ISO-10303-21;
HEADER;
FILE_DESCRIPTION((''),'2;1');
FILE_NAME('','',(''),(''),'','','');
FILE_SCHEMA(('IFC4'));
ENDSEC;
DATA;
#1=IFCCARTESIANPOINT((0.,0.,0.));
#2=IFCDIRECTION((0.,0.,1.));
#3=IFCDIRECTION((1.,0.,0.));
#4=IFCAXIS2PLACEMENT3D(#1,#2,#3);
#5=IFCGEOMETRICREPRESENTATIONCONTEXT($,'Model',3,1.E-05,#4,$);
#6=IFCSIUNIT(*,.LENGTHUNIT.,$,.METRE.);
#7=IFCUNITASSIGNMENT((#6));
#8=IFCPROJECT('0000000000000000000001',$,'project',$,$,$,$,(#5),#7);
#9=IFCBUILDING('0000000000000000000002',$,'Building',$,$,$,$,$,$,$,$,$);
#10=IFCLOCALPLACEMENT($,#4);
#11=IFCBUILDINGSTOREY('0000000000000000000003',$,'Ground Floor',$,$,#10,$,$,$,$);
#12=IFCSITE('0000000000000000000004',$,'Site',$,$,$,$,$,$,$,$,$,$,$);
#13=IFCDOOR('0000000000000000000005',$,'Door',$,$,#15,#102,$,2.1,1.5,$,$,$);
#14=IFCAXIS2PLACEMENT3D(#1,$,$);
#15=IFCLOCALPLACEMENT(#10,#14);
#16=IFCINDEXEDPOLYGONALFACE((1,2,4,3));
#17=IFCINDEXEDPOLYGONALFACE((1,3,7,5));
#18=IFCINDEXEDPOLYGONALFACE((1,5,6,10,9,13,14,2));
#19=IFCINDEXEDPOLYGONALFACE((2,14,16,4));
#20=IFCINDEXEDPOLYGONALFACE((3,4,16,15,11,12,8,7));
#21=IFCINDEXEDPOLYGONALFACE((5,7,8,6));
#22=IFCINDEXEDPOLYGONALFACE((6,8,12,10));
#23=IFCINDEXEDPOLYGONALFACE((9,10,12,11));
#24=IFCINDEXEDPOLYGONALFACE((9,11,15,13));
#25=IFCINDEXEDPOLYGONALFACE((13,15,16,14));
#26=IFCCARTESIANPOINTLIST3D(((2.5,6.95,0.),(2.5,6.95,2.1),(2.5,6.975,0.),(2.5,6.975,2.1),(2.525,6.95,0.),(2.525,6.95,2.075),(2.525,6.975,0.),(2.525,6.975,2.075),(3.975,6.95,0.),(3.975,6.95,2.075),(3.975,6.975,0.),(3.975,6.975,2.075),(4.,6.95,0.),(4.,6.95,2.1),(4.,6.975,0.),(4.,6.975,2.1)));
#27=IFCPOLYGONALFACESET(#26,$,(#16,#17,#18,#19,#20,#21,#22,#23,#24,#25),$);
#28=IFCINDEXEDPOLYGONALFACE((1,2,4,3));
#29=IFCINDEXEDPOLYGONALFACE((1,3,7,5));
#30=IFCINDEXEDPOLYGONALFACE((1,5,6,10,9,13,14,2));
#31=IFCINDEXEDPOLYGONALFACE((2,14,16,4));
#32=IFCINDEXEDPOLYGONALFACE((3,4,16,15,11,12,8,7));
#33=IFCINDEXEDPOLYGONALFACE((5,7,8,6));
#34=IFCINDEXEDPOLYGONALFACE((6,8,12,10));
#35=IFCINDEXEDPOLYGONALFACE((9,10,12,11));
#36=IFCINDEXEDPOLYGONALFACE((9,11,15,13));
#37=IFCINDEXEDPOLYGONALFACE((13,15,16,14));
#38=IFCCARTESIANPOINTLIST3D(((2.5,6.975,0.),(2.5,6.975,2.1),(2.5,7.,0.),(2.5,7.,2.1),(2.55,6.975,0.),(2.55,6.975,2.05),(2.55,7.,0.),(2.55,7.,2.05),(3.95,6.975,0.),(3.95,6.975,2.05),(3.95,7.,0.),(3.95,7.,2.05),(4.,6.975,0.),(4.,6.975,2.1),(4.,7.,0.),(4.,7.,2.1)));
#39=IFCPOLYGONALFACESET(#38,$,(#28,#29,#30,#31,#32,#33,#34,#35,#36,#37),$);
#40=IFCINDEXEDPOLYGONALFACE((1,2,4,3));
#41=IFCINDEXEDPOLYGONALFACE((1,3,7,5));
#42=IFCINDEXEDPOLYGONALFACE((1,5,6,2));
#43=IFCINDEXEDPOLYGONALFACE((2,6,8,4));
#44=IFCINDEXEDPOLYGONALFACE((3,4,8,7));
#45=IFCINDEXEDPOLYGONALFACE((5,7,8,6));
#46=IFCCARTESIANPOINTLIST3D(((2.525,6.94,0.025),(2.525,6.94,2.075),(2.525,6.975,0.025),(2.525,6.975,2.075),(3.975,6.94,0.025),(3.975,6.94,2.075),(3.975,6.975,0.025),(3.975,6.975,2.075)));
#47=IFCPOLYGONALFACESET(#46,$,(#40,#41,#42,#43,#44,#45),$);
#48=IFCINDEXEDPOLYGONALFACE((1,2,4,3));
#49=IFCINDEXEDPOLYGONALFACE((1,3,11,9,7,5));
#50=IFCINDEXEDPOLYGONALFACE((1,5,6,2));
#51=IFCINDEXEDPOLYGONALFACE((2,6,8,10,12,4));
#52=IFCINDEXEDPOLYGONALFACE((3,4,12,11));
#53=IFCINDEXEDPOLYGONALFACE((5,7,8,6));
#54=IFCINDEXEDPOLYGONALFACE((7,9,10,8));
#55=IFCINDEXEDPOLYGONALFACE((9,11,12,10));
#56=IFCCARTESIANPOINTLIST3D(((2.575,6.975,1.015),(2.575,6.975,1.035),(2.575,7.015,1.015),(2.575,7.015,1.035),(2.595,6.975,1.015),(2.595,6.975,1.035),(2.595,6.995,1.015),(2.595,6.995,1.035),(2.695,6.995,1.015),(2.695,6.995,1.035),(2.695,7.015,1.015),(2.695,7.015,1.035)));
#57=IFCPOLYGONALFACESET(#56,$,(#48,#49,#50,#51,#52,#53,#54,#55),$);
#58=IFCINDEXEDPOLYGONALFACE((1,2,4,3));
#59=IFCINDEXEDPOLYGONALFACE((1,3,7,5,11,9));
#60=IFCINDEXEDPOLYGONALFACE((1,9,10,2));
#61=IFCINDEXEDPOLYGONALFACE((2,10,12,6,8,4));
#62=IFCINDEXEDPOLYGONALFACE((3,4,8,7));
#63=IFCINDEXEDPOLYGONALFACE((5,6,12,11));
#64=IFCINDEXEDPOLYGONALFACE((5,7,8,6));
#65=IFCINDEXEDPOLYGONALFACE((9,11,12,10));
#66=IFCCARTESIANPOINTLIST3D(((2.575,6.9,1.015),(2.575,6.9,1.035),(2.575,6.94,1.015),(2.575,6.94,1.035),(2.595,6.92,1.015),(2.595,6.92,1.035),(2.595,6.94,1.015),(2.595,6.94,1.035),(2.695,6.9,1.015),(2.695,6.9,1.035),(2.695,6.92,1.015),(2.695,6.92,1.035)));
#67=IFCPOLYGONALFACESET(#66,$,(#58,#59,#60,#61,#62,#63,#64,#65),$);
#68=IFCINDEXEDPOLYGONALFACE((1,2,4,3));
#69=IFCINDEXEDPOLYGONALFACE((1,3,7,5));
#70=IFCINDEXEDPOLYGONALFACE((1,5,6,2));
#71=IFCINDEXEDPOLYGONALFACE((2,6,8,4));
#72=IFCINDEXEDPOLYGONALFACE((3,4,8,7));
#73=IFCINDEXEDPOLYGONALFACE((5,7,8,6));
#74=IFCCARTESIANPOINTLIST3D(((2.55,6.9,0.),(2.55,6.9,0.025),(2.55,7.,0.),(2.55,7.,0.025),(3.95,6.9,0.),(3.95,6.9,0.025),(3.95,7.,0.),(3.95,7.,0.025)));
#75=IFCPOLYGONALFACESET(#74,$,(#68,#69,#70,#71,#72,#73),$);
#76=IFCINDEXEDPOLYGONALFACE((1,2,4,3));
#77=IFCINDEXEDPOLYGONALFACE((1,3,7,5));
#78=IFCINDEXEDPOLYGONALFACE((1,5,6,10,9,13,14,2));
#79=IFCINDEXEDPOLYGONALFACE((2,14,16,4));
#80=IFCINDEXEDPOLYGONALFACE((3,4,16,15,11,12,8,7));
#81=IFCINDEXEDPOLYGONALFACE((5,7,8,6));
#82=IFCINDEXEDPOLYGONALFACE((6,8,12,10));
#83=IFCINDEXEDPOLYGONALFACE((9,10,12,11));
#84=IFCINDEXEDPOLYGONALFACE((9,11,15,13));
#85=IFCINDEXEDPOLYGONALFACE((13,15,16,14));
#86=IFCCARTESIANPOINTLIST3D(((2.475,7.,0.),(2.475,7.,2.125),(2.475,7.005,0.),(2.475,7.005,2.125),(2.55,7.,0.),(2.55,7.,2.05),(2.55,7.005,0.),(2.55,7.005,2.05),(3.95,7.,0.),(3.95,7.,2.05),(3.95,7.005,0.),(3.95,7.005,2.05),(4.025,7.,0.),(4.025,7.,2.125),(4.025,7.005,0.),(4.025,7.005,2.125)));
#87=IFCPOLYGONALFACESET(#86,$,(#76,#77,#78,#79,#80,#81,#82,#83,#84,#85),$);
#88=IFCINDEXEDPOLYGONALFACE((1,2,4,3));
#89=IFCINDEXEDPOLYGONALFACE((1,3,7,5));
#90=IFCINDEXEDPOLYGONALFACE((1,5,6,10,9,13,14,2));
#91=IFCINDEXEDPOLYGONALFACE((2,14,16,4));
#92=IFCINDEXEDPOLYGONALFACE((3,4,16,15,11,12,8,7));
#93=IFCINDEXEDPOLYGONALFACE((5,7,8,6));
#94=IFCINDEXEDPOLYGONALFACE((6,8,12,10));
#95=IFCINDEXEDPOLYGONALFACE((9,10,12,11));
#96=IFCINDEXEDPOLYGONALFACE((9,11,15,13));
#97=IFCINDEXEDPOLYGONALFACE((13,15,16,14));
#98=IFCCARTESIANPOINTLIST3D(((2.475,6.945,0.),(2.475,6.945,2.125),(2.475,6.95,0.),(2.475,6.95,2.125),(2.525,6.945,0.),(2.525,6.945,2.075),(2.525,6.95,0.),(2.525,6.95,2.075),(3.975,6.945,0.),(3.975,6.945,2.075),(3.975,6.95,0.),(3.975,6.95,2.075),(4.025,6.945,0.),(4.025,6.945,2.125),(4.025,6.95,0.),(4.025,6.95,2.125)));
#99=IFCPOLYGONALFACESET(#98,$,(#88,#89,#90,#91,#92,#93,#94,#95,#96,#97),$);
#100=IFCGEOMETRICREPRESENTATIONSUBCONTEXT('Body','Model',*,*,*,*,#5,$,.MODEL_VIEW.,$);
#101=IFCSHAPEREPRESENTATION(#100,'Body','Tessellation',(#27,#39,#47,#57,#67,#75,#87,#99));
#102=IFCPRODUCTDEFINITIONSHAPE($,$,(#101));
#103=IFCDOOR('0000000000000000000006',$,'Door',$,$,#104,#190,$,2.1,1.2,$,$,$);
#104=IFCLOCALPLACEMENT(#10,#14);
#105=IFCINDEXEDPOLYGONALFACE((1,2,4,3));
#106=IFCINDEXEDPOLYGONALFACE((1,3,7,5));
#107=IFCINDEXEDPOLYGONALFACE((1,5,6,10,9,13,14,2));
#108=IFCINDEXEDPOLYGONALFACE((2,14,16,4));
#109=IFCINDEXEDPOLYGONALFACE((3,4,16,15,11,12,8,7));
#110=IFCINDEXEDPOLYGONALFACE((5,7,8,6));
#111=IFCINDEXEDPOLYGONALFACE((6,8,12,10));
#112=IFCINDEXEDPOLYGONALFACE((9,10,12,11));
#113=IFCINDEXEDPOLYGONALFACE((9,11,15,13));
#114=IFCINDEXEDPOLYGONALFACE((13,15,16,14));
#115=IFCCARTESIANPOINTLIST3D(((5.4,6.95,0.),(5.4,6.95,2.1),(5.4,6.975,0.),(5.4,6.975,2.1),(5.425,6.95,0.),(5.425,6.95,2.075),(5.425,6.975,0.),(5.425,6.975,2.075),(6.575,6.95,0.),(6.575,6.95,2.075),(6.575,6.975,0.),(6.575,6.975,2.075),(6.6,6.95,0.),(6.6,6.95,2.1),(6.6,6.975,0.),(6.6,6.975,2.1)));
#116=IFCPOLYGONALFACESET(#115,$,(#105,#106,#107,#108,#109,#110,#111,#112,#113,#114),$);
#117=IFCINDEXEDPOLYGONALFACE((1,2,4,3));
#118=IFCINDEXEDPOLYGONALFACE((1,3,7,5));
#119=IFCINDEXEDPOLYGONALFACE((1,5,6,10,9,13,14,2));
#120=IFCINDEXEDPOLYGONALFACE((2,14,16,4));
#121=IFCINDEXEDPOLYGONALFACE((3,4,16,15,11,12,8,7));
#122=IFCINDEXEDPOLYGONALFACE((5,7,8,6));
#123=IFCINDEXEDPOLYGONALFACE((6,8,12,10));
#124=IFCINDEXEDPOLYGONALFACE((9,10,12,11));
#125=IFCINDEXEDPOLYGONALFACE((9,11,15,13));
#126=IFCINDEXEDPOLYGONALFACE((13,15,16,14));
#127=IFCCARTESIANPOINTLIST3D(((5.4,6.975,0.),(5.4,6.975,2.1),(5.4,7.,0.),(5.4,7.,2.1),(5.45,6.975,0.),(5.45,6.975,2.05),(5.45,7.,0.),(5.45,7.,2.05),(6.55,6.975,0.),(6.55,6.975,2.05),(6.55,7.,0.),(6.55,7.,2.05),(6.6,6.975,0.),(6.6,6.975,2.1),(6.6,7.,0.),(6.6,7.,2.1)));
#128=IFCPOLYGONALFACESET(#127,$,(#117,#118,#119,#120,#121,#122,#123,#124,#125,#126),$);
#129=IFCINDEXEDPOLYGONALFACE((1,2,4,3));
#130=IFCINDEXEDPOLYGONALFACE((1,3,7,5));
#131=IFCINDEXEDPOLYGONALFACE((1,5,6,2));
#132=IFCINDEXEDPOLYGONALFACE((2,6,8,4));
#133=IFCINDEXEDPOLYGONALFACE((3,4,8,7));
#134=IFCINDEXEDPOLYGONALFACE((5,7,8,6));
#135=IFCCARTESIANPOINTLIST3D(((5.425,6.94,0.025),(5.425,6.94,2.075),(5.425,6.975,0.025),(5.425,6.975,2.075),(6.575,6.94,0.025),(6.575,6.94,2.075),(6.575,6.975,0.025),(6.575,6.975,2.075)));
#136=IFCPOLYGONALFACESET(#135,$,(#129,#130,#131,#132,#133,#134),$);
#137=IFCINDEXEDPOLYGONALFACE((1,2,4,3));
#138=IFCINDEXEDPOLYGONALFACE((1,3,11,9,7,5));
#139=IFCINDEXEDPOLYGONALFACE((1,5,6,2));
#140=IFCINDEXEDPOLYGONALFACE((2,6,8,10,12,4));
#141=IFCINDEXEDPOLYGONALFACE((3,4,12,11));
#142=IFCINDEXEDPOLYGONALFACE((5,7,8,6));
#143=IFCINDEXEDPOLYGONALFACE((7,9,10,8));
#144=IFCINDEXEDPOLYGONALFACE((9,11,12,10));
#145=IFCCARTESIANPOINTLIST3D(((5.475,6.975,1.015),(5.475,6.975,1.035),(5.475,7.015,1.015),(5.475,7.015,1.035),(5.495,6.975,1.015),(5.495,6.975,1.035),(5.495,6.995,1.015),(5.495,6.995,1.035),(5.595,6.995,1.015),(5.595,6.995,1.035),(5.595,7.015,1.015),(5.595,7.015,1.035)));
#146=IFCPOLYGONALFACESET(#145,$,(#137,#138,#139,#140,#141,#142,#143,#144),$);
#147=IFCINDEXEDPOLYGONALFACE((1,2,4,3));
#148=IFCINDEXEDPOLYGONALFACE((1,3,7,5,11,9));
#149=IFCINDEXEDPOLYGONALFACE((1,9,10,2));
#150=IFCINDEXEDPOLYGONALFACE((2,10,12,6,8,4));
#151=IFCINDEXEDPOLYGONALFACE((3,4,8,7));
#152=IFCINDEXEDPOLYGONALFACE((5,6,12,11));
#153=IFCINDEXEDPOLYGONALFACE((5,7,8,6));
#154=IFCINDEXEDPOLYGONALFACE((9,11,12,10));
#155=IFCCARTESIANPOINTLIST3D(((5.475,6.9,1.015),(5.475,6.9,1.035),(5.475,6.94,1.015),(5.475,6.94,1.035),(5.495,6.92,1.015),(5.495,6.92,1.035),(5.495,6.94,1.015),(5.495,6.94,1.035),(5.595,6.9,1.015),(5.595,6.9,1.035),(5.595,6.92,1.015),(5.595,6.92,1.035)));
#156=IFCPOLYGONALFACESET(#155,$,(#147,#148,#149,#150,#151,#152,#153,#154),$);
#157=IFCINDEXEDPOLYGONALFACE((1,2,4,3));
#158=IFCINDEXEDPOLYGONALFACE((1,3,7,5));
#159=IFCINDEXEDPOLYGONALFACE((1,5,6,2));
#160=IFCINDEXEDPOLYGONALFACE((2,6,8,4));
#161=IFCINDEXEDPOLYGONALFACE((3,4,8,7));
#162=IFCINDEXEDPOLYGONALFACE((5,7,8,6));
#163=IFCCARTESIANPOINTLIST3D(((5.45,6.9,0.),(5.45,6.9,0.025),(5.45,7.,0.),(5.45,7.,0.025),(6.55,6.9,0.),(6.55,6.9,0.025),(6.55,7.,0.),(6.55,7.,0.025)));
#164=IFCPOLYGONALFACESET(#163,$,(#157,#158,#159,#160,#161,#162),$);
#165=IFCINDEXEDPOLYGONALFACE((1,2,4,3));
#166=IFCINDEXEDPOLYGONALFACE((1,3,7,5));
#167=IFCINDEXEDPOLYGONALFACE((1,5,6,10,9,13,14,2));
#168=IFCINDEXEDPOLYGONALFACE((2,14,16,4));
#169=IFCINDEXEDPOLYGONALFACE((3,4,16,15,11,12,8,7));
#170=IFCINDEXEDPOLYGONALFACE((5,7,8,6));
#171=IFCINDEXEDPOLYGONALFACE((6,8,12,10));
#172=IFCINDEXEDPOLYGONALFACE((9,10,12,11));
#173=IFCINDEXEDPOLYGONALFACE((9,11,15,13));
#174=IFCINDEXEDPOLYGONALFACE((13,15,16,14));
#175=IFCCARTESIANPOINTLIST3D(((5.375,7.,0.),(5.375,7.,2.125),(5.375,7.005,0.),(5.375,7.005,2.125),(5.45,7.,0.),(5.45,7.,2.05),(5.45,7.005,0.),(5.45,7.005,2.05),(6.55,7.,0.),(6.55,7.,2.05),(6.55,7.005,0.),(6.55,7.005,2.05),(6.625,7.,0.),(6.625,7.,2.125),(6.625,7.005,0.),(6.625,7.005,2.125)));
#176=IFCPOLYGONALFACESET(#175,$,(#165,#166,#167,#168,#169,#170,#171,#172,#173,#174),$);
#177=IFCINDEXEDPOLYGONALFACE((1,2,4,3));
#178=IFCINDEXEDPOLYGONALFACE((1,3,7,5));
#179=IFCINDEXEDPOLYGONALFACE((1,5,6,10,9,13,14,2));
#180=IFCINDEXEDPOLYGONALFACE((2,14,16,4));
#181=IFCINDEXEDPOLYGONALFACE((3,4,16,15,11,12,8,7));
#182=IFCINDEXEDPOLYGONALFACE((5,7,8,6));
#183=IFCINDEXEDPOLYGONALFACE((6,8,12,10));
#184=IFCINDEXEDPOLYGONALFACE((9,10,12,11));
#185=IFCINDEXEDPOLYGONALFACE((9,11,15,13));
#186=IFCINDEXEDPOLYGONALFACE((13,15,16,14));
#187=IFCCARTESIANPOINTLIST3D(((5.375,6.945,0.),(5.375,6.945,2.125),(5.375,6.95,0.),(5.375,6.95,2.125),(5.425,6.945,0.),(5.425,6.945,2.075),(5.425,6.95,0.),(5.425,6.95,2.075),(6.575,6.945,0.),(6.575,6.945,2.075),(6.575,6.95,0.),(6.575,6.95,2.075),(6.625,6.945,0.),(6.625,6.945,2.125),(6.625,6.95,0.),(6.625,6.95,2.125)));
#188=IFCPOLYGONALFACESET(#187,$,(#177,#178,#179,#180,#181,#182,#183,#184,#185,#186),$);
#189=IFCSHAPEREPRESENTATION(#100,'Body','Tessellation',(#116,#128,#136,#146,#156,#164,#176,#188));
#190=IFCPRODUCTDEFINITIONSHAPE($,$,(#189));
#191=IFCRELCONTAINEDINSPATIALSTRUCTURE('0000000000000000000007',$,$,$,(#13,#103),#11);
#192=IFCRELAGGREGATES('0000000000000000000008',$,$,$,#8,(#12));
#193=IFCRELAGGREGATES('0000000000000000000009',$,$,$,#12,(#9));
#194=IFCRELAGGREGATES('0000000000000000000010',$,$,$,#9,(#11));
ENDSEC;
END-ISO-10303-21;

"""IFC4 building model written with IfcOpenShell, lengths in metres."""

from ifc_helpers import new_model, si_unit, frame, origin_with_axes, place, context, subcontext, project, spatial, line, indexed_curve, outline, extrude, element, save


model = new_model("IFC4")

# Units and contexts
model_context = context("Model", 3, precision=1e-05, world=origin_with_axes())
body_context = subcontext(model_context, "Body", "Model", "MODEL_VIEW")
ifc_project = project(units=[si_unit("LENGTHUNIT", "METRE")], contexts=[model_context])

# Site, building, storey
site = spatial("IfcSite", under=ifc_project, Name="Site")
building = spatial("IfcBuilding", under=site, Name="Building")
storey_placement = place(None, origin_with_axes())
storey = spatial("IfcBuildingStorey", under=building, at=storey_placement, Name="Ground Floor")

# Doors
door_1_placement = place(storey_placement, frame((4.0, 7.0, 0.0), z_axis=(0.0, 0.0, 1.0), x_axis=(-1.0, 0.0, 0.0)))
element("IfcDoor", 1, at=door_1_placement, inside=storey, Name="Door", OverallHeight=2.1, OverallWidth=1.5, context=body_context, shape_type="SweptSolid", body=[
    extrude(outline(indexed_curve([(0.0, 0.0), (0.0, 2.1), (1.5, 2.1), (1.5, 0.0), (1.475, 0.0), (1.475, 2.075), (0.025, 2.075), (0.025, 0.0)], segments=[line(1, 2, 3, 4, 5, 6, 7, 8, 1)])), frame((0.0, 0.025, 0.0), z_axis=(0.0, -1.0, 0.0), x_axis=(1.0, 0.0, 0.0)), (0.0, 0.0, -1.0), 0.025),
    extrude(outline(indexed_curve([(0.0, 0.0), (0.0, 2.1), (1.5, 2.1), (1.5, 0.0), (1.45, 0.0), (1.45, 2.05), (0.05, 2.05), (0.05, 0.0)], segments=[line(1, 2, 3, 4, 5, 6, 7, 8, 1)])), frame((0.0, 0.0, 0.0), z_axis=(0.0, -1.0, 0.0), x_axis=(1.0, 0.0, 0.0)), (0.0, 0.0, -1.0), 0.025),
    extrude(outline(indexed_curve([(0.0, 0.0), (1.45, 0.0), (1.45, 0.035), (0.0, 0.035)], segments=[line(1, 2, 3, 4, 1)])), frame((0.025, 0.025, 0.025), z_axis=(0.0, 0.0, 1.0), x_axis=(1.0, 0.0, 0.0)), (0.0, 0.0, 1.0), 2.05),
    extrude(outline(indexed_curve([(0.0, 0.0), (0.0, -0.04), (-0.12, -0.04), (-0.12, -0.02), (-0.02, -0.02), (-0.02, 0.0)], segments=[line(1, 2, 3, 4, 5, 6, 1)])), frame((1.425, 0.025, 1.015), z_axis=(0.0, 0.0, 1.0), x_axis=(1.0, 0.0, 0.0)), (0.0, 0.0, 1.0), 0.02),
    extrude(outline(indexed_curve([(0.0, 0.0), (0.0, 0.04), (-0.12, 0.04), (-0.12, 0.02), (-0.02, 0.02), (-0.02, 0.0)], segments=[line(1, 2, 3, 4, 5, 6, 1)])), frame((1.425, 0.06, 1.015), z_axis=(0.0, 0.0, 1.0), x_axis=(1.0, 0.0, 0.0)), (0.0, 0.0, 1.0), 0.02),
    extrude(outline(indexed_curve([(0.0, 0.0), (1.4, 0.0), (1.4, 0.1), (0.0, 0.1)], segments=[line(1, 2, 3, 4, 1)])), frame((0.05, 0.0, 0.0), z_axis=(0.0, 0.0, 1.0), x_axis=(1.0, 0.0, 0.0)), (0.0, 0.0, 1.0), 0.025),
    extrude(outline(indexed_curve([(0.0, 0.0), (0.0, 2.125), (1.55, 2.125), (1.55, 0.0), (1.475, 0.0), (1.475, 2.05), (0.075, 2.05), (0.075, 0.0)], segments=[line(1, 2, 3, 4, 5, 6, 7, 8, 1)])), frame((-0.025, -0.005, 0.0), z_axis=(0.0, -1.0, 0.0), x_axis=(1.0, 0.0, 0.0)), (0.0, 0.0, -1.0), 0.005),
    extrude(outline(indexed_curve([(0.0, 0.0), (0.0, 2.125), (1.55, 2.125), (1.55, 0.0), (1.5, 0.0), (1.5, 2.075), (0.05, 2.075), (0.05, 0.0)], segments=[line(1, 2, 3, 4, 5, 6, 7, 8, 1)])), frame((-0.025, 0.05, 0.0), z_axis=(0.0, -1.0, 0.0), x_axis=(1.0, 0.0, 0.0)), (0.0, 0.0, -1.0), 0.005),
])
door_2_placement = place(storey_placement, frame((6.6, 7.0, 0.0), z_axis=(0.0, 0.0, 1.0), x_axis=(-1.0, 0.0, 0.0)))
element("IfcDoor", 2, at=door_2_placement, inside=storey, Name="Door", OverallHeight=2.1, OverallWidth=1.2, context=body_context, shape_type="SweptSolid", body=[
    extrude(outline(indexed_curve([(0.0, 0.0), (0.0, 2.1), (1.2, 2.1), (1.2, 0.0), (1.175, 0.0), (1.175, 2.075), (0.025, 2.075), (0.025, 0.0)], segments=[line(1, 2, 3, 4, 5, 6, 7, 8, 1)])), frame((0.0, 0.025, 0.0), z_axis=(0.0, -1.0, 0.0), x_axis=(1.0, 0.0, 0.0)), (0.0, 0.0, -1.0), 0.025),
    extrude(outline(indexed_curve([(0.0, 0.0), (0.0, 2.1), (1.2, 2.1), (1.2, 0.0), (1.15, 0.0), (1.15, 2.05), (0.05, 2.05), (0.05, 0.0)], segments=[line(1, 2, 3, 4, 5, 6, 7, 8, 1)])), frame((0.0, 0.0, 0.0), z_axis=(0.0, -1.0, 0.0), x_axis=(1.0, 0.0, 0.0)), (0.0, 0.0, -1.0), 0.025),
    extrude(outline(indexed_curve([(0.0, 0.0), (1.15, 0.0), (1.15, 0.035), (0.0, 0.035)], segments=[line(1, 2, 3, 4, 1)])), frame((0.025, 0.025, 0.025), z_axis=(0.0, 0.0, 1.0), x_axis=(1.0, 0.0, 0.0)), (0.0, 0.0, 1.0), 2.05),
    extrude(outline(indexed_curve([(0.0, 0.0), (0.0, -0.04), (-0.12, -0.04), (-0.12, -0.02), (-0.02, -0.02), (-0.02, 0.0)], segments=[line(1, 2, 3, 4, 5, 6, 1)])), frame((1.125, 0.025, 1.015), z_axis=(0.0, 0.0, 1.0), x_axis=(1.0, 0.0, 0.0)), (0.0, 0.0, 1.0), 0.02),
    extrude(outline(indexed_curve([(0.0, 0.0), (0.0, 0.04), (-0.12, 0.04), (-0.12, 0.02), (-0.02, 0.02), (-0.02, 0.0)], segments=[line(1, 2, 3, 4, 5, 6, 1)])), frame((1.125, 0.06, 1.015), z_axis=(0.0, 0.0, 1.0), x_axis=(1.0, 0.0, 0.0)), (0.0, 0.0, 1.0), 0.02),
    extrude(outline(indexed_curve([(0.0, 0.0), (1.1, 0.0), (1.1, 0.1), (0.0, 0.1)], segments=[line(1, 2, 3, 4, 1)])), frame((0.05, 0.0, 0.0), z_axis=(0.0, 0.0, 1.0), x_axis=(1.0, 0.0, 0.0)), (0.0, 0.0, 1.0), 0.025),
    extrude(outline(indexed_curve([(0.0, 0.0), (0.0, 2.125), (1.25, 2.125), (1.25, 0.0), (1.175, 0.0), (1.175, 2.05), (0.075, 2.05), (0.075, 0.0)], segments=[line(1, 2, 3, 4, 5, 6, 7, 8, 1)])), frame((-0.025, -0.005, 0.0), z_axis=(0.0, -1.0, 0.0), x_axis=(1.0, 0.0, 0.0)), (0.0, 0.0, -1.0), 0.005),
    extrude(outline(indexed_curve([(0.0, 0.0), (0.0, 2.125), (1.25, 2.125), (1.25, 0.0), (1.2, 0.0), (1.2, 2.075), (0.05, 2.075), (0.05, 0.0)], segments=[line(1, 2, 3, 4, 5, 6, 7, 8, 1)])), frame((-0.025, 0.05, 0.0), z_axis=(0.0, -1.0, 0.0), x_axis=(1.0, 0.0, 0.0)), (0.0, 0.0, -1.0), 0.005),
])

save(model, "model.ifc")
